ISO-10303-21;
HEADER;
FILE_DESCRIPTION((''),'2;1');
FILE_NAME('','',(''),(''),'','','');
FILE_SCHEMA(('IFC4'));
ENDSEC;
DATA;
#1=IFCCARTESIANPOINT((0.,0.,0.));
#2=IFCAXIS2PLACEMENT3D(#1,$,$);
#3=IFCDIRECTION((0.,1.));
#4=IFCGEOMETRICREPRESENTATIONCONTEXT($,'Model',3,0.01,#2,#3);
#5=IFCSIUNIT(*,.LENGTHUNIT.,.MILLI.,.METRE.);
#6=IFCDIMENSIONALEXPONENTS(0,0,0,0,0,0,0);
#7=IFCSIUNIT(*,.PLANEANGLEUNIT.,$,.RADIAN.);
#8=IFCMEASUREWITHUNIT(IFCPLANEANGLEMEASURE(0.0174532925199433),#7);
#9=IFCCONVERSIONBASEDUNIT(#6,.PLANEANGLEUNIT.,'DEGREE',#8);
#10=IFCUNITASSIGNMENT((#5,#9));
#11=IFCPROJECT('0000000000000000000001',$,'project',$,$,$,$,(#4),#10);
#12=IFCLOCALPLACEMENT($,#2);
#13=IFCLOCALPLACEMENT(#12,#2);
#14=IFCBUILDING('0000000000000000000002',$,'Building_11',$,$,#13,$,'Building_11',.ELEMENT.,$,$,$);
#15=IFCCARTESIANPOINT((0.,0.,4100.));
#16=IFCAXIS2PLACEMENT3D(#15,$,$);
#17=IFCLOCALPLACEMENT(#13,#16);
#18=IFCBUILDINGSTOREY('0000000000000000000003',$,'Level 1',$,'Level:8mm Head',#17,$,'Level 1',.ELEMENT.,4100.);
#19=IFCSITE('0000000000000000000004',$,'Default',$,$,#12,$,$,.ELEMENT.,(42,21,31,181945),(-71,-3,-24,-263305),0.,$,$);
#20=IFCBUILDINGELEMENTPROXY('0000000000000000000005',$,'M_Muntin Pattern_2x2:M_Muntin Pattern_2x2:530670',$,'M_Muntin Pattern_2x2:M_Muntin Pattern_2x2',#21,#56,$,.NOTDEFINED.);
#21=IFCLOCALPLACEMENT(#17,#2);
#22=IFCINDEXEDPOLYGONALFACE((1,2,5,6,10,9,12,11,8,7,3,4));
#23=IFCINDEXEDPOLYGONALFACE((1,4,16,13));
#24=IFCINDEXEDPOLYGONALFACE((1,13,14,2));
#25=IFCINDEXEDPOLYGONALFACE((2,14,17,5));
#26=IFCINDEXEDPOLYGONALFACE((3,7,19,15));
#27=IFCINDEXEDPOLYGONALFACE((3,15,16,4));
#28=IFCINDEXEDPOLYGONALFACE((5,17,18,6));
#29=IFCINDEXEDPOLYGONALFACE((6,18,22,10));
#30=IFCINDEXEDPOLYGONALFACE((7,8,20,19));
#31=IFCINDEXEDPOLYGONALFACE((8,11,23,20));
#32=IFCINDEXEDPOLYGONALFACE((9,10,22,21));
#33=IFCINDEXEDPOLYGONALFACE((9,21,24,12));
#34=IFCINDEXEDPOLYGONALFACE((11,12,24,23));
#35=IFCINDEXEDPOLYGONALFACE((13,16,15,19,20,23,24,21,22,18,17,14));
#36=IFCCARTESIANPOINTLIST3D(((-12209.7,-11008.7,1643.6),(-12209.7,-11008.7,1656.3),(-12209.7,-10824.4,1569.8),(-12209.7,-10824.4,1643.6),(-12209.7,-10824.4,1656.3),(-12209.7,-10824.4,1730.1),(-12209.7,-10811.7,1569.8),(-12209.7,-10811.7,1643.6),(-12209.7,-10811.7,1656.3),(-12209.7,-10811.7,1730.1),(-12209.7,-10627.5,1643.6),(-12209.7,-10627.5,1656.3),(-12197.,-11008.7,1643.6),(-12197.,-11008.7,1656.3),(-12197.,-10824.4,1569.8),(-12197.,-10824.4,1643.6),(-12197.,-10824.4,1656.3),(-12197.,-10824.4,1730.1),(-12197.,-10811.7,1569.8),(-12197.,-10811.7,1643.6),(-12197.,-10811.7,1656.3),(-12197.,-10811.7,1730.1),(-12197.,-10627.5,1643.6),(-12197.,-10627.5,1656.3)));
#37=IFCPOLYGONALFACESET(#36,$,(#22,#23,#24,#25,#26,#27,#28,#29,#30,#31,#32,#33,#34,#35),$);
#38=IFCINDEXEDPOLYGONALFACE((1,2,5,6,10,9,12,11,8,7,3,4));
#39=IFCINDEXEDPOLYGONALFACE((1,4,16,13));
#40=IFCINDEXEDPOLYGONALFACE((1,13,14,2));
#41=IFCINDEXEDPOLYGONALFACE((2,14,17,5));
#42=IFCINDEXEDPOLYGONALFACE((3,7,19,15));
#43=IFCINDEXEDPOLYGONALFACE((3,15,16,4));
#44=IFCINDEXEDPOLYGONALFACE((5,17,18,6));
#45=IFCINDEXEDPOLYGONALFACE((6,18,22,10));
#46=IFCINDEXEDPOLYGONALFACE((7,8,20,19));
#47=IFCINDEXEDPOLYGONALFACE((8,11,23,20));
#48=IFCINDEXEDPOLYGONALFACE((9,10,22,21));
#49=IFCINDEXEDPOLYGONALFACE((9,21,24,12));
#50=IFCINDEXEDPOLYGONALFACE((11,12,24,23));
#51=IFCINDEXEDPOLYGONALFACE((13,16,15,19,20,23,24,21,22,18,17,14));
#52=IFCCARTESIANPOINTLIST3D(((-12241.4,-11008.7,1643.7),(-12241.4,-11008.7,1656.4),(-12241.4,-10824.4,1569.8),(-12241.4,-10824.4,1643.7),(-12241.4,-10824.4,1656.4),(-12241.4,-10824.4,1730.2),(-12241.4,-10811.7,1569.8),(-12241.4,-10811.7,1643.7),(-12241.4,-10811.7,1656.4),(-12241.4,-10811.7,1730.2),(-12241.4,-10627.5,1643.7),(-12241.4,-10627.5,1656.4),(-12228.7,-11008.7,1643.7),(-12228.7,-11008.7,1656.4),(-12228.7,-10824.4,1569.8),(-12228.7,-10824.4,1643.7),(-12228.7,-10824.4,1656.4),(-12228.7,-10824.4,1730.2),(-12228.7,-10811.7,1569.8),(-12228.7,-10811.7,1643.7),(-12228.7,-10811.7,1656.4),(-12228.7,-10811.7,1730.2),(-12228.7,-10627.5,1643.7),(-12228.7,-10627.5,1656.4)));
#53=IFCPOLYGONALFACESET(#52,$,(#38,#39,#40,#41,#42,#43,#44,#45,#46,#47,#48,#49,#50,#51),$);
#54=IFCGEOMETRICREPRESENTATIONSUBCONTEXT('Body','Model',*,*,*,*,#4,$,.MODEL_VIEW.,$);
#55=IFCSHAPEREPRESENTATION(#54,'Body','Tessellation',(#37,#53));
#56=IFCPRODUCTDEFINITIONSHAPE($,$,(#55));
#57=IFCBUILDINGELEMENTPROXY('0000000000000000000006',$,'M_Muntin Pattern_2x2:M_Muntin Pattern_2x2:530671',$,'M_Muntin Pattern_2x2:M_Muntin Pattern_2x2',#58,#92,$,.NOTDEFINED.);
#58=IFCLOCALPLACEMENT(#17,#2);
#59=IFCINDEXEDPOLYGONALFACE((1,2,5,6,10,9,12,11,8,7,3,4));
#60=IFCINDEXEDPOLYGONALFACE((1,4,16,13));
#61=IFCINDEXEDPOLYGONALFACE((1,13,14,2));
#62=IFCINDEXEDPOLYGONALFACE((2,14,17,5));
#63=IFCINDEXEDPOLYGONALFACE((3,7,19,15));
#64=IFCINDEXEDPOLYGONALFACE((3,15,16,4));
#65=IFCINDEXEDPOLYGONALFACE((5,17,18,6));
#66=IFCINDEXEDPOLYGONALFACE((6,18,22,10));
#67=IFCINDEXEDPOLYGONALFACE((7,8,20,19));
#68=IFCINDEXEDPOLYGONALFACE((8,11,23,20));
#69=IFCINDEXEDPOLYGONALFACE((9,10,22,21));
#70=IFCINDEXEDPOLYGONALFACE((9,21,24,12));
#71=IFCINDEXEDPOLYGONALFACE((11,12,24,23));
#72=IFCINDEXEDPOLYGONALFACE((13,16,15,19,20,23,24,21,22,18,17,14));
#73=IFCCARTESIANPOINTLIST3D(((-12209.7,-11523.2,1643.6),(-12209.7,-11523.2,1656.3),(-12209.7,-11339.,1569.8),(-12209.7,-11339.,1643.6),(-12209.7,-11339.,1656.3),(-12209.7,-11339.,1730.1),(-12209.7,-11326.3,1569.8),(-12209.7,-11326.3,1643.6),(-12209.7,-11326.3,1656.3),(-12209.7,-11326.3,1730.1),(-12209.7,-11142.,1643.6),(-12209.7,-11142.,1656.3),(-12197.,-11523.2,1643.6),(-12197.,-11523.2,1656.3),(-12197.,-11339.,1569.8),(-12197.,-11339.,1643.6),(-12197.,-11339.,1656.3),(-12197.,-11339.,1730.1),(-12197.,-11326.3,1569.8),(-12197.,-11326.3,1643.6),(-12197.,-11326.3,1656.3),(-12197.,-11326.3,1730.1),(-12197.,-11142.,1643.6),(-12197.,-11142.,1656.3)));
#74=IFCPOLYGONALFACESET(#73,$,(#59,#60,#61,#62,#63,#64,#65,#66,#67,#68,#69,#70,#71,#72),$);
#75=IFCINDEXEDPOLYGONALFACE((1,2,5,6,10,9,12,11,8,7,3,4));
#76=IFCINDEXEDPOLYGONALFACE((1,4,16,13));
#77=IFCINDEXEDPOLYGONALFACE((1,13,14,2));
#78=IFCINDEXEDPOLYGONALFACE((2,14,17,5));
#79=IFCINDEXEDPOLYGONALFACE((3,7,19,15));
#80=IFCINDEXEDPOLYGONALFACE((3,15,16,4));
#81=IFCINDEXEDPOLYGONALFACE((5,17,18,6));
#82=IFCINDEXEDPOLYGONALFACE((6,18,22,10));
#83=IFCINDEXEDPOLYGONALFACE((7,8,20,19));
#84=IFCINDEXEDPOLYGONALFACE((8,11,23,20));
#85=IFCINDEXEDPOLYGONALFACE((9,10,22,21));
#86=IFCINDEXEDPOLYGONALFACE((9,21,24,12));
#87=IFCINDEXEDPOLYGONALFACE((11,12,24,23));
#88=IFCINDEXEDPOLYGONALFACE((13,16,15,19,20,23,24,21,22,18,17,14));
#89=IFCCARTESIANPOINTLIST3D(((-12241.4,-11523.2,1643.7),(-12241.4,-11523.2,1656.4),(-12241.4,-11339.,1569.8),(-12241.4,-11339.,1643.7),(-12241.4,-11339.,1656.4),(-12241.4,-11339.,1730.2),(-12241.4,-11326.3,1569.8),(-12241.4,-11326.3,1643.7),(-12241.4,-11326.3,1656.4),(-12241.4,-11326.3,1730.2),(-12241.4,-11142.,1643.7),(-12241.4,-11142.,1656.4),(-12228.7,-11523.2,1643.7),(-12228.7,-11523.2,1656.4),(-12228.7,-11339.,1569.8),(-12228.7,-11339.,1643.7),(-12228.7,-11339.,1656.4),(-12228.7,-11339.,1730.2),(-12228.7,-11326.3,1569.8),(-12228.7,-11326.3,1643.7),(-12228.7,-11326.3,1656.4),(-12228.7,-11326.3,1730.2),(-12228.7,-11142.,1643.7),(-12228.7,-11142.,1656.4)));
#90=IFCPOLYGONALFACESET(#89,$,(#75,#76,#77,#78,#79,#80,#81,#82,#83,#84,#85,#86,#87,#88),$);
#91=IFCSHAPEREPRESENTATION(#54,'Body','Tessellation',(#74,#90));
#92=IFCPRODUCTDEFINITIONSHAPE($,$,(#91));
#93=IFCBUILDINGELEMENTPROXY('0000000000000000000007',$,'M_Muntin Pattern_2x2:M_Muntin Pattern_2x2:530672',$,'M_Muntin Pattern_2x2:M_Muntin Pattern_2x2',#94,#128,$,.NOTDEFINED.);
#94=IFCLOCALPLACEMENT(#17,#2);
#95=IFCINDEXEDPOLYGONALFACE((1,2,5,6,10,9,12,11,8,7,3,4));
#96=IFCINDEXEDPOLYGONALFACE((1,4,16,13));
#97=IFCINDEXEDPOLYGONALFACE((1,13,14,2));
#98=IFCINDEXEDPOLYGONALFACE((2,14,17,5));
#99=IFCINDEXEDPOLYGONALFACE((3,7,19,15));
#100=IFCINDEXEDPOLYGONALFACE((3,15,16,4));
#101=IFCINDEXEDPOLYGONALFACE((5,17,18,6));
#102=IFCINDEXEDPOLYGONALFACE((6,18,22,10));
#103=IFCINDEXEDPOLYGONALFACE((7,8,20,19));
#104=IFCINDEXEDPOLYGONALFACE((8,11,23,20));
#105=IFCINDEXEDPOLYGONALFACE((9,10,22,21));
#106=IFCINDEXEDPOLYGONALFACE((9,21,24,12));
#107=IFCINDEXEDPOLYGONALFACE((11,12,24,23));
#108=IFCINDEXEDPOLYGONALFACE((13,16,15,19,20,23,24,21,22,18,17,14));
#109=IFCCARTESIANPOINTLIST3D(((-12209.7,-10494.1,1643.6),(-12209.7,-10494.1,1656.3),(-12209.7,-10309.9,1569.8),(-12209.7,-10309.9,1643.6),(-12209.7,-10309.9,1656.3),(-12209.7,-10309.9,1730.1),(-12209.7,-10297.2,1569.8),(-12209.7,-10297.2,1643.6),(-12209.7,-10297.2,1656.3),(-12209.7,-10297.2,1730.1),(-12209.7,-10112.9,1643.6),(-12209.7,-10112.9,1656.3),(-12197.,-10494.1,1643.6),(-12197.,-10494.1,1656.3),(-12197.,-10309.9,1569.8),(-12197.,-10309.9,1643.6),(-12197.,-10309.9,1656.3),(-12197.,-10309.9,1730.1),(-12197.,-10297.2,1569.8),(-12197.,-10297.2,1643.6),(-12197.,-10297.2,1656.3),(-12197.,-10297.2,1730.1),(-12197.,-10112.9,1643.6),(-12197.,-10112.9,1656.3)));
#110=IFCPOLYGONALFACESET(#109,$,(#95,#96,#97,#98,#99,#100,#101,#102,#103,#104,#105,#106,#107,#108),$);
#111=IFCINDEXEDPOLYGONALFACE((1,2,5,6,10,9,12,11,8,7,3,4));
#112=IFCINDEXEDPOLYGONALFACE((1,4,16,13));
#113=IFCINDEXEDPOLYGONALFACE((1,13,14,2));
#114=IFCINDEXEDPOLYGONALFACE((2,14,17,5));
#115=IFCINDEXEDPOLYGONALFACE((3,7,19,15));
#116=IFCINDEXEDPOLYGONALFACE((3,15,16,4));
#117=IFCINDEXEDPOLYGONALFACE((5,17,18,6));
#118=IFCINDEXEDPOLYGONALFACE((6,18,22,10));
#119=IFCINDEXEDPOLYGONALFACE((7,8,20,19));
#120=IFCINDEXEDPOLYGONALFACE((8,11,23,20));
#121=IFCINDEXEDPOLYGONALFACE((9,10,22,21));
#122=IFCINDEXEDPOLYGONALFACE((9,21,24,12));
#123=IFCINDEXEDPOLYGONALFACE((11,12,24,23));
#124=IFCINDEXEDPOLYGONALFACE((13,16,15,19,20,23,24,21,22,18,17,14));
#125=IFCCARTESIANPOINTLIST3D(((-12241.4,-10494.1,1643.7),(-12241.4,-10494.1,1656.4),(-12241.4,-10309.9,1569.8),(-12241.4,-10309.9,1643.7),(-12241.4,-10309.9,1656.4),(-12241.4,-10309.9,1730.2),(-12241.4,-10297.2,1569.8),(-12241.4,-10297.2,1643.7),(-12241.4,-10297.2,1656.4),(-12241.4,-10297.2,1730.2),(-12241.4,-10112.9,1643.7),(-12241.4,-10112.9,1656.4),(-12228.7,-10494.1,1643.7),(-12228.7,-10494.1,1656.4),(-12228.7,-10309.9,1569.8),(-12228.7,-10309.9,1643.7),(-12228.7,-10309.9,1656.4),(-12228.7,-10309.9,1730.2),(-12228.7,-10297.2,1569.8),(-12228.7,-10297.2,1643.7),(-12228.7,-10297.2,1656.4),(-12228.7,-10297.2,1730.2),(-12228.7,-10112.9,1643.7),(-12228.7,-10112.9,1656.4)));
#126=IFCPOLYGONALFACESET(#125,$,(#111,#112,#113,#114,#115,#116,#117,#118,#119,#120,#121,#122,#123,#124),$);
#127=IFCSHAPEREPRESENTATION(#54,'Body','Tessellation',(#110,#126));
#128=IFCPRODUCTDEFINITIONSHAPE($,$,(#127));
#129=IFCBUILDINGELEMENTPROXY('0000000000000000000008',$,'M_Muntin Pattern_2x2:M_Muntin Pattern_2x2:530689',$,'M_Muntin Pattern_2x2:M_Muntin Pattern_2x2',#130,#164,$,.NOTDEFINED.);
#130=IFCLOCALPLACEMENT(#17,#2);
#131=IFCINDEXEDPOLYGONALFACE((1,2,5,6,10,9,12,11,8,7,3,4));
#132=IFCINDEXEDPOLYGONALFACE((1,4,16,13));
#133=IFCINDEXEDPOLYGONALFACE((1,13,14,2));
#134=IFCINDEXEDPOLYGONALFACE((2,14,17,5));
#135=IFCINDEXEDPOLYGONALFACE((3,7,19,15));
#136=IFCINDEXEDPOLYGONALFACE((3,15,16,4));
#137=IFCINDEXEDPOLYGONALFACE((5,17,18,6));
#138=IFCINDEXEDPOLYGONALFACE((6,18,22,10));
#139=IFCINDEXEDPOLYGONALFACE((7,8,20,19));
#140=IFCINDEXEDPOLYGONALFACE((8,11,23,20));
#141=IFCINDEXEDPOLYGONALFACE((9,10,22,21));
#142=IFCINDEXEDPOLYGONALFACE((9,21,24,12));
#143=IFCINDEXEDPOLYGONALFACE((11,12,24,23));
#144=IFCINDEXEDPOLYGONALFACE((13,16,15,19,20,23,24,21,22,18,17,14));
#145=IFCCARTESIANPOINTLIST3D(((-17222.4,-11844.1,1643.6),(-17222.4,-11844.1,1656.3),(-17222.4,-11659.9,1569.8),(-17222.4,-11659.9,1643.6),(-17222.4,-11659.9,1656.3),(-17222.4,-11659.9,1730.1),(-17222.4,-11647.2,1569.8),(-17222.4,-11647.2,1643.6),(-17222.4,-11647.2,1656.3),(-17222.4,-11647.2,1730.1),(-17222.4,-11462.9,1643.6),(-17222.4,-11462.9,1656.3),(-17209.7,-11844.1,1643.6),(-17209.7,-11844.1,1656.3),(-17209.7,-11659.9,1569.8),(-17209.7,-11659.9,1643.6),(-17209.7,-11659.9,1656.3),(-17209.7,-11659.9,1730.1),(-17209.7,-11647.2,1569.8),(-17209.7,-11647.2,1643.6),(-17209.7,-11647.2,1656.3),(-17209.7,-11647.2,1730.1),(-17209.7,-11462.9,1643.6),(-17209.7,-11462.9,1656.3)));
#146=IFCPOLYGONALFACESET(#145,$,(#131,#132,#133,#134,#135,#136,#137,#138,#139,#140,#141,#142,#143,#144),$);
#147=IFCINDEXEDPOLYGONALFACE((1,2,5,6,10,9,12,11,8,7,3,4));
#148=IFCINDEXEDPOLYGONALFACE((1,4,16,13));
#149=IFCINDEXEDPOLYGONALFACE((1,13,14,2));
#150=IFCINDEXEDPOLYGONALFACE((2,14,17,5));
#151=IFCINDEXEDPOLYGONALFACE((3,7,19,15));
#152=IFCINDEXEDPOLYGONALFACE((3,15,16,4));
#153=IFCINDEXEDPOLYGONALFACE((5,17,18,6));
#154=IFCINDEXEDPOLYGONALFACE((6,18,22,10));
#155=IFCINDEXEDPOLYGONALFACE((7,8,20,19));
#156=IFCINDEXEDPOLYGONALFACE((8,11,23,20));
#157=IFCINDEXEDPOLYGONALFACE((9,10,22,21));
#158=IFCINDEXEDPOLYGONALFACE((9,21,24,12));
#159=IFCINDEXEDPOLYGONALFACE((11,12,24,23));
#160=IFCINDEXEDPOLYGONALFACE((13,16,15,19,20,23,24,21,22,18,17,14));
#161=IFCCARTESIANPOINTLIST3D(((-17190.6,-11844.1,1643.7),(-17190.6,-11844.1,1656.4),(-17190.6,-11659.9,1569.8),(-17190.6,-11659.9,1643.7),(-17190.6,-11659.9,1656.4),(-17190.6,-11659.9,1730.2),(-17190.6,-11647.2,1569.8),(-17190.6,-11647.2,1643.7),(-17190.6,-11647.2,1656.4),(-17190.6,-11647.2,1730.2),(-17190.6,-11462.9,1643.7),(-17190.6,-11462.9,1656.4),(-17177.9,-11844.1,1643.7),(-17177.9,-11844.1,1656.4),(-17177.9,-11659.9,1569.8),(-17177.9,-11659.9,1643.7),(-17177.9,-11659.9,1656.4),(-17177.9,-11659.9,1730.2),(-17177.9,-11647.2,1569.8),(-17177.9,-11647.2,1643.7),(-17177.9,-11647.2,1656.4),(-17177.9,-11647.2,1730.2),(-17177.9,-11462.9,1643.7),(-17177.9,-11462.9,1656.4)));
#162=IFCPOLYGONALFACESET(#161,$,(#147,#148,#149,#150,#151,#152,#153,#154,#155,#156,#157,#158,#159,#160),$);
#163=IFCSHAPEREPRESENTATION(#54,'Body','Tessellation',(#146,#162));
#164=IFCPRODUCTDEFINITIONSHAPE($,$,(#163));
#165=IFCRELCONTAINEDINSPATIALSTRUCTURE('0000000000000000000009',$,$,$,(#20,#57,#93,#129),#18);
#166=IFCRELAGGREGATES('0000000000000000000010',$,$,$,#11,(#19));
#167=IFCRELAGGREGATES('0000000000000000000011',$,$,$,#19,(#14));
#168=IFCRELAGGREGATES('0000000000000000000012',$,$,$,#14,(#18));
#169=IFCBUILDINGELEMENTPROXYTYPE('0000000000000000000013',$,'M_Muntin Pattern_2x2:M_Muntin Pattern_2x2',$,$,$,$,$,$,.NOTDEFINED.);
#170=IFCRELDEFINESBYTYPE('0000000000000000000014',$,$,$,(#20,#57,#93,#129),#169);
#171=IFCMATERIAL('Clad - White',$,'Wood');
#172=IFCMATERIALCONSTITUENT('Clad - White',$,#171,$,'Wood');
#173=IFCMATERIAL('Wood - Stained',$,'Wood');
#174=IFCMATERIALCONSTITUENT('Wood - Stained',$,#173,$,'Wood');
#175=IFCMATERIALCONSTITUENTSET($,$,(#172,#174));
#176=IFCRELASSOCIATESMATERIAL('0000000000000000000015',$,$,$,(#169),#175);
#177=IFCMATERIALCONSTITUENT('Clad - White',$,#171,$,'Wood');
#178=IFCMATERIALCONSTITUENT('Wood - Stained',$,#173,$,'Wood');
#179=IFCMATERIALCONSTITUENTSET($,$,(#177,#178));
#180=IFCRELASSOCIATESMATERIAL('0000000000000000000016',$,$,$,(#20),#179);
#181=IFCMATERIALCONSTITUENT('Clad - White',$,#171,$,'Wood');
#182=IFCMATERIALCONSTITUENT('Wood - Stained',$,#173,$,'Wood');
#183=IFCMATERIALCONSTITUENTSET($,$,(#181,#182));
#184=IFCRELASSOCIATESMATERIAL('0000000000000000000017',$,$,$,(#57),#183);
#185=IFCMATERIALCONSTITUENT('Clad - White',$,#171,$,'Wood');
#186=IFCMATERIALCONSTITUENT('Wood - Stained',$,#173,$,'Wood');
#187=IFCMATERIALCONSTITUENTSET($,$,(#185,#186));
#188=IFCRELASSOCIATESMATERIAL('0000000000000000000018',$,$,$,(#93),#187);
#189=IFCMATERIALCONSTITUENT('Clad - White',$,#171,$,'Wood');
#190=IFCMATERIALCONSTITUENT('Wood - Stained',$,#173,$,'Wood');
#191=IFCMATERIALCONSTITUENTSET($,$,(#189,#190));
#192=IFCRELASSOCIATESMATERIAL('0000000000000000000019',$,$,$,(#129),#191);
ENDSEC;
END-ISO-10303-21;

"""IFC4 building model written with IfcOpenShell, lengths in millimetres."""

from ifc_helpers import new_model, entity, si_unit, converted_unit, direction, frame, origin, place, context, subcontext, project, spatial, indexed_curve, outline, extrude, source, transform, mapped, material, constituent, constituent_set, type_object, type_shapes, element, save


model = new_model("IFC4")

# Units and contexts
model_context = context("Model", 3, precision=0.01, world=origin(), true_north=direction((0.0, 1.0)))
body_context = subcontext(model_context, "Body", "Model", "MODEL_VIEW")
ifc_project = project(units=[si_unit("LENGTHUNIT", "METRE", prefix="MILLI"), converted_unit("PLANEANGLEUNIT", "DEGREE", entity("IfcPlaneAngleMeasure", 0.0174532925199433), si_unit("PLANEANGLEUNIT", "RADIAN"), dimensions=[0, 0, 0, 0, 0, 0, 0])], contexts=[model_context])

# Site, building, storey
site_placement = place(None, origin())
site = spatial("IfcSite", under=ifc_project, at=site_placement, Name="Default", CompositionType="ELEMENT", RefLatitude=(42, 21, 31, 181945), RefLongitude=(-71, -3, -24, -263305), RefElevation=0.0)
building_placement = place(site_placement, origin())
building = spatial("IfcBuilding", under=site, at=building_placement, Name="Building_11", LongName="Building_11", CompositionType="ELEMENT")
storey_placement = place(building_placement, frame((0.0, 0.0, 4100.0)))
storey = spatial("IfcBuildingStorey", under=building, at=storey_placement, Name="Level 1", ObjectType="Level:8mm Head", LongName="Level 1", CompositionType="ELEMENT", Elevation=4100.0)

# Building element proxies
ifc_material_1 = material(Name="Clad - White", Category="Wood")
ifc_material_2 = material(Name="Wood - Stained", Category="Wood")
ifc_constituent_1 = constituent(ifc_material_1, Name="Clad - White", Category="Wood")
ifc_constituent_2 = constituent(ifc_material_2, Name="Wood - Stained", Category="Wood")
ifc_constituent_set_1 = constituent_set(constituents=[ifc_constituent_1, ifc_constituent_2])
building_element_proxy_type_1 = type_object("IfcBuildingElementProxyType", Name="M_Muntin Pattern_2x2:M_Muntin Pattern_2x2", PredefinedType="NOTDEFINED", material=ifc_constituent_set_1)
shared_shape_1 = source(origin(), body_context, "Body", "SweptSolid", [
    extrude(outline(indexed_curve([(6.4, -6.4), (80.1, -6.4), (80.1, 6.3), (6.4, 6.3), (6.4, 190.6), (-6.3, 190.6), (-6.3, 6.3), (-80.2, 6.3), (-80.2, -6.4), (-6.3, -6.4), (-6.3, -190.6), (6.4, -190.6), (6.4, -6.4)], self_intersect=False)), frame((0.0, 9.5, 80.1), z_axis=(0.0, 1.0, 0.0), x_axis=(0.0, 0.0, 1.0)), (0.0, 0.0, 1.0), 12.7),
    extrude(outline(indexed_curve([(6.4, -6.4), (80.2, -6.4), (80.2, 6.3), (6.4, 6.3), (6.4, 190.6), (-6.3, 190.6), (-6.3, 6.3), (-80.2, 6.3), (-80.2, -6.4), (-6.3, -6.4), (-6.3, -190.6), (6.4, -190.6), (6.4, -6.4)], self_intersect=False)), frame((0.0, -22.2, 80.2), z_axis=(0.0, 1.0, 0.0), x_axis=(0.0, 0.0, 1.0)), (0.0, 0.0, 1.0), 12.7),
])
type_shapes(building_element_proxy_type_1, [shared_shape_1])
ifc_constituent_3 = constituent(ifc_material_1, Name="Clad - White", Category="Wood")
ifc_constituent_4 = constituent(ifc_material_2, Name="Wood - Stained", Category="Wood")
ifc_constituent_set_2 = constituent_set(constituents=[ifc_constituent_3, ifc_constituent_4])
proxy_1_placement = place(storey_placement, frame((-12219.2, -10818.1, 1569.8), z_axis=(0.0, 0.0, 1.0), x_axis=(0.0, -1.0, 0.0)))
element("IfcBuildingElementProxy", 1, at=proxy_1_placement, inside=storey, type_object=building_element_proxy_type_1, material=ifc_constituent_set_2, Name="M_Muntin Pattern_2x2:M_Muntin Pattern_2x2:530670", ObjectType="M_Muntin Pattern_2x2:M_Muntin Pattern_2x2", PredefinedType="NOTDEFINED", context=body_context, shape_type="MappedRepresentation", body=[
    mapped(shared_shape_1, transform((0.0, 0.0, 0.0), scale=1.0)),
])
ifc_constituent_5 = constituent(ifc_material_1, Name="Clad - White", Category="Wood")
ifc_constituent_6 = constituent(ifc_material_2, Name="Wood - Stained", Category="Wood")
ifc_constituent_set_3 = constituent_set(constituents=[ifc_constituent_5, ifc_constituent_6])
proxy_2_placement = place(storey_placement, frame((-12219.2, -11332.6, 1569.8), z_axis=(0.0, 0.0, 1.0), x_axis=(0.0, -1.0, 0.0)))
element("IfcBuildingElementProxy", 2, at=proxy_2_placement, inside=storey, type_object=building_element_proxy_type_1, material=ifc_constituent_set_3, Name="M_Muntin Pattern_2x2:M_Muntin Pattern_2x2:530671", ObjectType="M_Muntin Pattern_2x2:M_Muntin Pattern_2x2", PredefinedType="NOTDEFINED", context=body_context, shape_type="MappedRepresentation", body=[
    mapped(shared_shape_1, transform((0.0, 0.0, 0.0), scale=1.0)),
])
ifc_constituent_7 = constituent(ifc_material_1, Name="Clad - White", Category="Wood")
ifc_constituent_8 = constituent(ifc_material_2, Name="Wood - Stained", Category="Wood")
ifc_constituent_set_4 = constituent_set(constituents=[ifc_constituent_7, ifc_constituent_8])
proxy_3_placement = place(storey_placement, frame((-12219.2, -10303.5, 1569.8), z_axis=(0.0, 0.0, 1.0), x_axis=(0.0, -1.0, 0.0)))
element("IfcBuildingElementProxy", 3, at=proxy_3_placement, inside=storey, type_object=building_element_proxy_type_1, material=ifc_constituent_set_4, Name="M_Muntin Pattern_2x2:M_Muntin Pattern_2x2:530672", ObjectType="M_Muntin Pattern_2x2:M_Muntin Pattern_2x2", PredefinedType="NOTDEFINED", context=body_context, shape_type="MappedRepresentation", body=[
    mapped(shared_shape_1, transform((0.0, 0.0, 0.0), scale=1.0)),
])
ifc_constituent_9 = constituent(ifc_material_1, Name="Clad - White", Category="Wood")
ifc_constituent_10 = constituent(ifc_material_2, Name="Wood - Stained", Category="Wood")
ifc_constituent_set_5 = constituent_set(constituents=[ifc_constituent_9, ifc_constituent_10])
proxy_4_placement = place(storey_placement, frame((-17200.2, -11653.5, 1569.8), z_axis=(0.0, 0.0, 1.0), x_axis=(0.0, 1.0, 0.0)))
element("IfcBuildingElementProxy", 4, at=proxy_4_placement, inside=storey, type_object=building_element_proxy_type_1, material=ifc_constituent_set_5, Name="M_Muntin Pattern_2x2:M_Muntin Pattern_2x2:530689", ObjectType="M_Muntin Pattern_2x2:M_Muntin Pattern_2x2", PredefinedType="NOTDEFINED", context=body_context, shape_type="MappedRepresentation", body=[
    mapped(shared_shape_1, transform((0.0, 0.0, 0.0), scale=1.0)),
])

save(model, "model.ifc")
